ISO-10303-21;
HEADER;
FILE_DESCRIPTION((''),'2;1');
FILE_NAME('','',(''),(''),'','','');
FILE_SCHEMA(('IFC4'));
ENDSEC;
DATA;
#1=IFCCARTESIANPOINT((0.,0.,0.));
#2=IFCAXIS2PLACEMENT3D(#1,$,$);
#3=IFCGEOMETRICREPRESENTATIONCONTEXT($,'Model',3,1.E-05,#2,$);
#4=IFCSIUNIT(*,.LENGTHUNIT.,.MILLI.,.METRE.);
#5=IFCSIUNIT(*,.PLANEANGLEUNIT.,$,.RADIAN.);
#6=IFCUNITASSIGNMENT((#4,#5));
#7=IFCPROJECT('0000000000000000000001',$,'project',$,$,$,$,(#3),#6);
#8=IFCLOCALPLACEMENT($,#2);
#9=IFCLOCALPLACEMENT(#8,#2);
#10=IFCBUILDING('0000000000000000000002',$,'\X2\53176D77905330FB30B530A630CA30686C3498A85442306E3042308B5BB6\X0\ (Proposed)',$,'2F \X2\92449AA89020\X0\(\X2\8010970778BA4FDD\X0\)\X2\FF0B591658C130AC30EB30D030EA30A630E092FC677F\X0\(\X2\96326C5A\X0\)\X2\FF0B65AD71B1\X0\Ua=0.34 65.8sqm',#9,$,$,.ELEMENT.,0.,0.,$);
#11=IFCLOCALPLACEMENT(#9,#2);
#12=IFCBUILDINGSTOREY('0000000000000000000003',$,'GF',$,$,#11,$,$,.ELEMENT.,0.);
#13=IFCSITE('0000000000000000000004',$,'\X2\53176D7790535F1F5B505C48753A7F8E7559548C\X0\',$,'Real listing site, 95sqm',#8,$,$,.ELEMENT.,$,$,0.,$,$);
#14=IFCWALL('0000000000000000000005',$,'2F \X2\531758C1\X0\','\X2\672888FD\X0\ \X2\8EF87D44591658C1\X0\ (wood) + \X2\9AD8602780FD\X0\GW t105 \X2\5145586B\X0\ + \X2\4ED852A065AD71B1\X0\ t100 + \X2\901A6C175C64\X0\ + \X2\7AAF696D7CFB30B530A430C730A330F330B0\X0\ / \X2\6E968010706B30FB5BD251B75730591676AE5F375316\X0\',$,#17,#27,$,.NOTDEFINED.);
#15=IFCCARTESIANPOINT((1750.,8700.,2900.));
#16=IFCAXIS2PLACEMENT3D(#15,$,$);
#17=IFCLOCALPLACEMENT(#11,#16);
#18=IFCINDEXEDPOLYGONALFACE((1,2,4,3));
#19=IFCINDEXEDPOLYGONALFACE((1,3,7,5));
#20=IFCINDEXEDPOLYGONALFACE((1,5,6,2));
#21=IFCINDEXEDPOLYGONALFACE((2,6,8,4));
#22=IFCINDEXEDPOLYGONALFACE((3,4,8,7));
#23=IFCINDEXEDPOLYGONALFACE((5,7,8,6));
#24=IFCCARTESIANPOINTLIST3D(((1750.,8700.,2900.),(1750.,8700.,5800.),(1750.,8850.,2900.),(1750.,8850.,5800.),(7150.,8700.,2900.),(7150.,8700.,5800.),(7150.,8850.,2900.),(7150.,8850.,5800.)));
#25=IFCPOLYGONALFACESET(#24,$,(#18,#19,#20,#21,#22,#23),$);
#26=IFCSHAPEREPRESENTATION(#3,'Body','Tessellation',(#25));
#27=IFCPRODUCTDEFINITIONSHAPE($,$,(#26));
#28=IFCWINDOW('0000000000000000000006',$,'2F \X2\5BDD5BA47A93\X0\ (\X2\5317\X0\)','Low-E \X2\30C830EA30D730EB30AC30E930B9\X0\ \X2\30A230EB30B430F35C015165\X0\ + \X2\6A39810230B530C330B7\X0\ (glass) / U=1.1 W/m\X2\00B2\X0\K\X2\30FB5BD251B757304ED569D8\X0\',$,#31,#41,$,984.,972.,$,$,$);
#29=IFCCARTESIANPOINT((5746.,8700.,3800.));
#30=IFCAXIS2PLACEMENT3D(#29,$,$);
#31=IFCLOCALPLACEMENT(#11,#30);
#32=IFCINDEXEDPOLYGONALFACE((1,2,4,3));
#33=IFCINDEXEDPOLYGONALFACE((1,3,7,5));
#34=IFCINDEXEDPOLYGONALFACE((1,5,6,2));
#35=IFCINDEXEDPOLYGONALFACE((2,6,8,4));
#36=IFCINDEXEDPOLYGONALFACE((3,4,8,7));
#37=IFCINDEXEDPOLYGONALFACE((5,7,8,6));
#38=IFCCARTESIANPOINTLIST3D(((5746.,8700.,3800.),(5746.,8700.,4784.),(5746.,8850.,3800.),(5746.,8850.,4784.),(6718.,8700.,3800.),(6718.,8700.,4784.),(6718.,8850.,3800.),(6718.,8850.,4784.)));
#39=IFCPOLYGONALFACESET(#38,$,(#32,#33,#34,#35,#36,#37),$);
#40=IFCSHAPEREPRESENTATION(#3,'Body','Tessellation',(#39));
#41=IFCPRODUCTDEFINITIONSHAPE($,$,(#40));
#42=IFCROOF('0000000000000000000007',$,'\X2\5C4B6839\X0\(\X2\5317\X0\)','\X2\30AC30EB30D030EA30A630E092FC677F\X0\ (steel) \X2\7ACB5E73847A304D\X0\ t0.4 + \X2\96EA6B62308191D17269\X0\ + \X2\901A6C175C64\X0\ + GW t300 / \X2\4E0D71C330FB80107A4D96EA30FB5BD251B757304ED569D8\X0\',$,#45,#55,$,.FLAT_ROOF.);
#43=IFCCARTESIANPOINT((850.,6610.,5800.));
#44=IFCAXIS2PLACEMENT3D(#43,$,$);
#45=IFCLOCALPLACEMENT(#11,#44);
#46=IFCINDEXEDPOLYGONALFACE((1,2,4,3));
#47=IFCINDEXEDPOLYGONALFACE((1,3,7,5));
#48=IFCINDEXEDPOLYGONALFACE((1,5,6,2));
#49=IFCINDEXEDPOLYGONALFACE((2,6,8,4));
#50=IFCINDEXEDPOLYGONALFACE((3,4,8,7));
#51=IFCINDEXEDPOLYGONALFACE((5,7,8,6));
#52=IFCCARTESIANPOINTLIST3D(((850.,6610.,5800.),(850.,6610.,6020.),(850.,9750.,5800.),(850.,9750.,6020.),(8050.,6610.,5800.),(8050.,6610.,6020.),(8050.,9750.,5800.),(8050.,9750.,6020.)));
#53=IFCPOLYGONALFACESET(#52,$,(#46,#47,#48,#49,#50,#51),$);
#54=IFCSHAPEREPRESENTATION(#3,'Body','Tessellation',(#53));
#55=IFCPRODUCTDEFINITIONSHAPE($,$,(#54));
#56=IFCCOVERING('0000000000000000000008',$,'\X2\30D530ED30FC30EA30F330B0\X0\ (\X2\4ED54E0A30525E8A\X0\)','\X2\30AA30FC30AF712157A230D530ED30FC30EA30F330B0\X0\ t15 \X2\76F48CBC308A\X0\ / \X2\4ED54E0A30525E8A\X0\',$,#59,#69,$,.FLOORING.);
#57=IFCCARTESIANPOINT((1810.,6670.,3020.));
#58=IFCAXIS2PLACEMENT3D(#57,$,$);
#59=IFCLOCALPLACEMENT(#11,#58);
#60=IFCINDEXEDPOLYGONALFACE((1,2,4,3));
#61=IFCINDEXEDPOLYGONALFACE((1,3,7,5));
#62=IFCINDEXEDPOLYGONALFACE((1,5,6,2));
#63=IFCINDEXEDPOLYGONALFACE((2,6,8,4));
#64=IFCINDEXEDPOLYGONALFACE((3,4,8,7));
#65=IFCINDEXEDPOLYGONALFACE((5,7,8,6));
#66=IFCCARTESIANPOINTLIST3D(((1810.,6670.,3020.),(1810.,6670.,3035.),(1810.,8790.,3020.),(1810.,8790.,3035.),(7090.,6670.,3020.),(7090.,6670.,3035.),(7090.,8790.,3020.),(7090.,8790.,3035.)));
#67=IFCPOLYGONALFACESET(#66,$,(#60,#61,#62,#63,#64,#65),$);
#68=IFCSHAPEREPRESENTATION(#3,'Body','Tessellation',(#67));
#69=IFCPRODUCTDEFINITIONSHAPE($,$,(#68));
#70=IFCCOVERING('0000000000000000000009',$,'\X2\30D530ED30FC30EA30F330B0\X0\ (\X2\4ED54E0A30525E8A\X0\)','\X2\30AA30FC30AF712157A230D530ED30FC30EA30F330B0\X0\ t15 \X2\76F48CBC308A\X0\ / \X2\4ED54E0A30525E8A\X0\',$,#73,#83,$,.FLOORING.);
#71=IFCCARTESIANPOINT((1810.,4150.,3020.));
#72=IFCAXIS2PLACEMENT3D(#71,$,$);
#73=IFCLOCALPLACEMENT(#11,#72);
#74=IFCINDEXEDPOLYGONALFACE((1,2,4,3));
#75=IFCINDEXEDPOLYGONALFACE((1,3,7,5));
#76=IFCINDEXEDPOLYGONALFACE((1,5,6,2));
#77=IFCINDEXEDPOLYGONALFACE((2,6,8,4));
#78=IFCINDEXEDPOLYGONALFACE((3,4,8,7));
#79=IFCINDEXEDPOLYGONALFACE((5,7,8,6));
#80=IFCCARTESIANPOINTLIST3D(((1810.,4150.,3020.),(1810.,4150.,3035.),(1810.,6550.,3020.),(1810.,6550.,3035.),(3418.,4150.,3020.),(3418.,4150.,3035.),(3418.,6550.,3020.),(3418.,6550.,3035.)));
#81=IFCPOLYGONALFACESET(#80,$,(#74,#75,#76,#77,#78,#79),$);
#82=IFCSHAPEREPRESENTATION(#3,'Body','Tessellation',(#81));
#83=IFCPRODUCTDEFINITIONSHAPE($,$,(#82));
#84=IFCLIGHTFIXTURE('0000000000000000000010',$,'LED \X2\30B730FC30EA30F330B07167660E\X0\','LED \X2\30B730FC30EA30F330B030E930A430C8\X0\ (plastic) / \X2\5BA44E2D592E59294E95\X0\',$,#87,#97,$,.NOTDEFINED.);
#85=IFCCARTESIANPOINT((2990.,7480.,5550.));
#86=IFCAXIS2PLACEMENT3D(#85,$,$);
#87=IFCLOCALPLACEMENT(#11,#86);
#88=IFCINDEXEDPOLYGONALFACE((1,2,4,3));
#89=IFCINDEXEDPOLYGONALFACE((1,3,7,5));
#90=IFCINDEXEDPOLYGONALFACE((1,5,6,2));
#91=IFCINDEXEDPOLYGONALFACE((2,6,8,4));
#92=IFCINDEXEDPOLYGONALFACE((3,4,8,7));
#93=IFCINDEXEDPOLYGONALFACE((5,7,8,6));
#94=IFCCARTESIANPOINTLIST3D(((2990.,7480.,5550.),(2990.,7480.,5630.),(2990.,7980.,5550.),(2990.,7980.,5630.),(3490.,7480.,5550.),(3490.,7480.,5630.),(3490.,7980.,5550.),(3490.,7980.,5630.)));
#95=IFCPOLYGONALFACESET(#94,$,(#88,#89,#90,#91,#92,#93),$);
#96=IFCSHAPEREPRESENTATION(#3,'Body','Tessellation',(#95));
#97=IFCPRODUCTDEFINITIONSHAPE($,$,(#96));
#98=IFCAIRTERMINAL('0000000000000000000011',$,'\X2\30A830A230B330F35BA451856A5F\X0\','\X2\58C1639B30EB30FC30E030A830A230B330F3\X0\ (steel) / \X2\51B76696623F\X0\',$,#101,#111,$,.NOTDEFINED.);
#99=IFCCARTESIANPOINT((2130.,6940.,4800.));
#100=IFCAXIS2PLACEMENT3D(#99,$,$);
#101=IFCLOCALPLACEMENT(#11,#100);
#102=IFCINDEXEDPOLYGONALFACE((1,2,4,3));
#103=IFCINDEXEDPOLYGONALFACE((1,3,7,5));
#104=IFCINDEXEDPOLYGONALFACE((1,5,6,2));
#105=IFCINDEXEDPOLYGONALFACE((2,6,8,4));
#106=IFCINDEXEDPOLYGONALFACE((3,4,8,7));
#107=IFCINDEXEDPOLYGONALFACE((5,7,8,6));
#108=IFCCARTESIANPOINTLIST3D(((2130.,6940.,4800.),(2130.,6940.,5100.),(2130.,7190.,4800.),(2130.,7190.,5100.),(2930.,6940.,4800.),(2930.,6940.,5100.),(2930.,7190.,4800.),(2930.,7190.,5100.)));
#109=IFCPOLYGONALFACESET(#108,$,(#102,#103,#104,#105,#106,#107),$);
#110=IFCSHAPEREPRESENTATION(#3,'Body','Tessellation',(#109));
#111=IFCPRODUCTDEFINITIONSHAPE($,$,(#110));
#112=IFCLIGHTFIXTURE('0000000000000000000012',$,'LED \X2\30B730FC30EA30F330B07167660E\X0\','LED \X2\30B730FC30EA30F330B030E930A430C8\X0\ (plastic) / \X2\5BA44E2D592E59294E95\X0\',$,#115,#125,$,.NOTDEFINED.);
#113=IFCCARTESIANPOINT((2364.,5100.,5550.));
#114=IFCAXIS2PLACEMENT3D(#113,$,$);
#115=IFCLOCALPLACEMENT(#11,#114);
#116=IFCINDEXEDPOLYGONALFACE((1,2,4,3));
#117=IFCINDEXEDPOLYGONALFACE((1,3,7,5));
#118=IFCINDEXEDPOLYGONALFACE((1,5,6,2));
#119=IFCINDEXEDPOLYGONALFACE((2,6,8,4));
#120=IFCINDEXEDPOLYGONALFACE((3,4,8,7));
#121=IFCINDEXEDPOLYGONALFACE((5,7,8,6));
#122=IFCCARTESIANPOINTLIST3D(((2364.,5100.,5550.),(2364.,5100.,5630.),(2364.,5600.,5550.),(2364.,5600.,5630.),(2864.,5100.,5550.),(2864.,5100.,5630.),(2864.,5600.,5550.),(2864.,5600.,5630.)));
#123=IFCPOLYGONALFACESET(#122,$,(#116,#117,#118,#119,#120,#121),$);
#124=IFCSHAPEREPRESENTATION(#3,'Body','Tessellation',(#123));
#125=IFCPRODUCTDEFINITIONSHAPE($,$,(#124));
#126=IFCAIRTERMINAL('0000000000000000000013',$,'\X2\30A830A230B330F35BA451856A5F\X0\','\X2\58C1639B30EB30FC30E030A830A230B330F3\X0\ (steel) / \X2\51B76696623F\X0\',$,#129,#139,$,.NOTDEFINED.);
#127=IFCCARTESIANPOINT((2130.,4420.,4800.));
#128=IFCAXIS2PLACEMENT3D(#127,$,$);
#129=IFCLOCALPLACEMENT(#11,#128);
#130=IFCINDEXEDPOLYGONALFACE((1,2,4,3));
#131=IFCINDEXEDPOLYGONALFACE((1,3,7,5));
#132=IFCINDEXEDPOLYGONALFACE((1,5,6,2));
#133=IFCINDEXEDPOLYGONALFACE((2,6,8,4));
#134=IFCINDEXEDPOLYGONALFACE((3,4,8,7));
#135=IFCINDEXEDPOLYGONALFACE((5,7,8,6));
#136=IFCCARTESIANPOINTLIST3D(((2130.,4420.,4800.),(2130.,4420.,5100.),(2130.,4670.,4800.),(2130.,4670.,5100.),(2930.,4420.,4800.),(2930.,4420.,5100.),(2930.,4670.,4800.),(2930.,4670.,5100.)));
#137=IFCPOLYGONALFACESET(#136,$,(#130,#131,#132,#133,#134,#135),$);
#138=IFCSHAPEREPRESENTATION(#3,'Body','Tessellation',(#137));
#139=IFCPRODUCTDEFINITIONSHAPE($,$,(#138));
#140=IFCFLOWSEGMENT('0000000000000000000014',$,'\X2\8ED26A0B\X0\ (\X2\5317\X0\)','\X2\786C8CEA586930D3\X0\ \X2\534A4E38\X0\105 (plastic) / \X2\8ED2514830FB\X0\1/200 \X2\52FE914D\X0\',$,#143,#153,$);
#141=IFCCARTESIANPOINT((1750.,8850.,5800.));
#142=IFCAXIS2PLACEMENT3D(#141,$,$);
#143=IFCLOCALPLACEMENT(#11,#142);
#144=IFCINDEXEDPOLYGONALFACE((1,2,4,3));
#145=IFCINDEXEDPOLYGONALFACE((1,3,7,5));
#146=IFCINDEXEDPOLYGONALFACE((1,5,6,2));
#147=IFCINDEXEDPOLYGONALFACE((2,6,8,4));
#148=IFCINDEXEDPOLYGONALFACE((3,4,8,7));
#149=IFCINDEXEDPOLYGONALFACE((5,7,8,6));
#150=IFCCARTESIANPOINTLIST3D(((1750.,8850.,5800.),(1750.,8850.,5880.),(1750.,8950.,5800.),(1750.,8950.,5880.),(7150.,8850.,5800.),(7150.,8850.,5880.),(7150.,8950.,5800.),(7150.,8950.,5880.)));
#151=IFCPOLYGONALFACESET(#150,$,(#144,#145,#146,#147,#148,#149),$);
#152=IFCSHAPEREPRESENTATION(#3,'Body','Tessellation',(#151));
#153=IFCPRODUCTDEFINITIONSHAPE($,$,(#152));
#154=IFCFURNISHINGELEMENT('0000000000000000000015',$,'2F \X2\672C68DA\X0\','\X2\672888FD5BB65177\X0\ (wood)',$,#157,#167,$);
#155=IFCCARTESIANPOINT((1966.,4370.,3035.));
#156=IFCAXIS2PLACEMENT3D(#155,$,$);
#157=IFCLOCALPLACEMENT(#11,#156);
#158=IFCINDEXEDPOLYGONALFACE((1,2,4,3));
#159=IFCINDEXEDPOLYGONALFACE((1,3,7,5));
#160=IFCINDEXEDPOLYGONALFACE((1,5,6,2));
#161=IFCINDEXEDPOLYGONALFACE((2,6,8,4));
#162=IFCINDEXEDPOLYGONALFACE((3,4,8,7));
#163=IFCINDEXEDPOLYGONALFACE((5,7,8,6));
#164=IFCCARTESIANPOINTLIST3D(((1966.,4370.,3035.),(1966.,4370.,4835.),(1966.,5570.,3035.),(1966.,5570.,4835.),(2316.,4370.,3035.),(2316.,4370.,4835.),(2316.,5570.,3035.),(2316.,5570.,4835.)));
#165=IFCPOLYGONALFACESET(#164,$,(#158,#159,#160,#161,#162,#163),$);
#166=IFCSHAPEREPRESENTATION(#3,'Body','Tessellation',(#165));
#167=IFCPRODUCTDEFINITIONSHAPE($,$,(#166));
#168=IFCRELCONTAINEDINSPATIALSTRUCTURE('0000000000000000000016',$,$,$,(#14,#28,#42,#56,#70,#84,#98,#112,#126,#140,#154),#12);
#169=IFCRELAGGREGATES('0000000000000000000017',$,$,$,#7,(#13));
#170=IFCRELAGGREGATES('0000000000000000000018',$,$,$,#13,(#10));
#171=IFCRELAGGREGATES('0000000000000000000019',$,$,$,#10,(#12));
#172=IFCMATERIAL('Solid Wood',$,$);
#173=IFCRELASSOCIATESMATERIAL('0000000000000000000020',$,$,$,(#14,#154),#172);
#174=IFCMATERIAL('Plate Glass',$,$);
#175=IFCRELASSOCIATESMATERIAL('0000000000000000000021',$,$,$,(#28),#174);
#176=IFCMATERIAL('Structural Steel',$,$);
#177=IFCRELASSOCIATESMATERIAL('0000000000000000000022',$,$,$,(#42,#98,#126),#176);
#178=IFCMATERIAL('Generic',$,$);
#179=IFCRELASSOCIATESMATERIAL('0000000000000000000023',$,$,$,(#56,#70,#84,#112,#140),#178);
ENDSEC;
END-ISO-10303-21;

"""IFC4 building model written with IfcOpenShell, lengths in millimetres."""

from ifc_helpers import new_model, si_unit, frame, frame_2d, origin, place, context, project, spatial, rectangle, extrude, material, element, fill, save


model = new_model("IFC4")

# Units and contexts
model_context = context("Model", 3, precision=1e-05, world=origin())
ifc_project = project(units=[si_unit("LENGTHUNIT", "METRE", prefix="MILLI"), si_unit("PLANEANGLEUNIT", "RADIAN")], contexts=[model_context])

# Site, building, storey
site_placement = place(None, origin())
site = spatial("IfcSite", under=ifc_project, at=site_placement, Name="北海道弟子屈町美留和", ObjectType="Real listing site, 95sqm", CompositionType="ELEMENT", RefElevation=0.0)
building_placement = place(site_placement, origin())
building = spatial("IfcBuilding", under=site, at=building_placement, Name="北海道・サウナと水風呂のある家 (Proposed)", ObjectType="2F 鉄骨造(耐震確保)＋外壁ガルバリウム鋼板(防汚)＋断熱Ua=0.34 65.8sqm", CompositionType="ELEMENT", ElevationOfRefHeight=0.0, ElevationOfTerrain=0.0)
storey_placement = place(building_placement, origin())
storey = spatial("IfcBuildingStorey", under=building, at=storey_placement, Name="GF", CompositionType="ELEMENT", Elevation=0.0)

# Shared definitions
ifc_material_1 = material(Name="Solid Wood")

# Wall, opening, window
wall_placement = place(storey_placement, frame((1750.0, 8700.0, 2900.0)))
wall = element("IfcWall", 1, at=wall_placement, inside=storey, material=ifc_material_1, Name="2F 北壁", Description="木製 軸組外壁 (wood) + 高性能GW t105 充填 + 付加断熱 t100 + 通気層 + 窯業系サイディング / 準耐火・寒冷地外皮強化", PredefinedType="NOTDEFINED", context=model_context, shape_type="SweptSolid", body=[
    extrude(rectangle(XDim=5400.0, YDim=150.0, at=frame_2d((2700.0, 75.0))), frame((1750.0, 8700.0, 2900.0)), (0.0, 0.0, 1.0), 2900.0),
])
opening_placement = place(storey_placement, frame((5746.0, 8700.0, 3800.0)))
opening = element("IfcOpeningElement", 2, at=opening_placement, cuts=wall, PredefinedType="NOTDEFINED", context=model_context, shape_type="SweptSolid", body=[
    extrude(rectangle(XDim=972.0, YDim=150.0, at=frame_2d((486.0, 75.0))), frame((5746.0, 8700.0, 3800.0)), (0.0, 0.0, 1.0), 984.0),
])
ifc_material_2 = material(Name="Plate Glass")
window_placement = place(storey_placement, frame((5746.0, 8700.0, 3800.0)))
window = element("IfcWindow", 3, at=window_placement, inside=storey, material=ifc_material_2, Name="2F 寝室窓 (北)", Description="Low-E トリプルガラス アルゴン封入 + 樹脂サッシ (glass) / U=1.1 W/m²K・寒冷地仕様", OverallHeight=984.0, OverallWidth=972.0, context=model_context, shape_type="SweptSolid", body=[
    extrude(rectangle(XDim=972.0, YDim=150.0, at=frame_2d((486.0, 75.0))), frame((5746.0, 8700.0, 3800.0)), (0.0, 0.0, 1.0), 984.0),
])
fill(opening, window)

# Roof
ifc_material_3 = material(Name="Structural Steel")
for number, where, name in (
    (4, (850.0, 6610.0, 5800.0), "屋根(北)"),
):
    element("IfcRoof", number, at=place(storey_placement, frame(where)), inside=storey, material=ifc_material_3, Name=name, Description="ガルバリウム鋼板 (steel) 立平葺き t0.4 + 雪止め金物 + 通気層 + GW t300 / 不燃・耐積雪・寒冷地仕様", PredefinedType="FLAT_ROOF", context=model_context, shape_type="SweptSolid", body=[
        extrude(rectangle(XDim=7200.0, YDim=3140.0, at=frame_2d((3600.0, 1570.0))), frame((850.0, 6610.0, 5800.0)), (0.0, 0.0, 1.0), 220.0),
    ])

# Coverings
ifc_material_4 = material(Name="Generic")
covering_1_placement = place(storey_placement, frame((1810.0, 6670.0, 3020.0)))
element("IfcCovering", 5, at=covering_1_placement, inside=storey, material=ifc_material_4, Name="フローリング (仕上げ床)", Description="オーク無垢フローリング t15 直貼り / 仕上げ床", PredefinedType="FLOORING", context=model_context, shape_type="SweptSolid", body=[
    extrude(rectangle(XDim=5280.0, YDim=2120.0, at=frame_2d((2640.0, 1060.0))), frame((1810.0, 6670.0, 3020.0)), (0.0, 0.0, 1.0), 15.0),
])
covering_2_placement = place(storey_placement, frame((1810.0, 4150.0, 3020.0)))
element("IfcCovering", 6, at=covering_2_placement, inside=storey, material=ifc_material_4, Name="フローリング (仕上げ床)", Description="オーク無垢フローリング t15 直貼り / 仕上げ床", PredefinedType="FLOORING", context=model_context, shape_type="SweptSolid", body=[
    extrude(rectangle(XDim=1608.0, YDim=2400.0, at=frame_2d((804.0, 1200.0))), frame((1810.0, 4150.0, 3020.0)), (0.0, 0.0, 1.0), 15.0),
])

# Light fixture
light_fixture_1_placement = place(storey_placement, frame((2990.0, 7480.0, 5550.0)))
element("IfcLightFixture", 7, at=light_fixture_1_placement, inside=storey, material=ifc_material_4, Name="LED シーリング照明", Description="LED シーリングライト (plastic) / 室中央天井", PredefinedType="NOTDEFINED", context=model_context, shape_type="SweptSolid", body=[
    extrude(rectangle(XDim=500.0, YDim=500.0, at=frame_2d((250.0, 250.0))), frame((2990.0, 7480.0, 5550.0)), (0.0, 0.0, 1.0), 80.0),
])

# Air terminal
air_terminal_1_placement = place(storey_placement, frame((2130.0, 6940.0, 4800.0)))
element("IfcAirTerminal", 8, at=air_terminal_1_placement, inside=storey, material=ifc_material_3, Name="エアコン室内機", Description="壁掛ルームエアコン (steel) / 冷暖房", PredefinedType="NOTDEFINED", context=model_context, shape_type="SweptSolid", body=[
    extrude(rectangle(XDim=800.0, YDim=250.0, at=frame_2d((400.0, 125.0))), frame((2130.0, 6940.0, 4800.0)), (0.0, 0.0, 1.0), 300.0),
])

# Light fixture
light_fixture_2_placement = place(storey_placement, frame((2364.0, 5100.0, 5550.0)))
element("IfcLightFixture", 9, at=light_fixture_2_placement, inside=storey, material=ifc_material_4, Name="LED シーリング照明", Description="LED シーリングライト (plastic) / 室中央天井", PredefinedType="NOTDEFINED", context=model_context, shape_type="SweptSolid", body=[
    extrude(rectangle(XDim=500.0, YDim=500.0, at=frame_2d((250.0, 250.0))), frame((2364.0, 5100.0, 5550.0)), (0.0, 0.0, 1.0), 80.0),
])

# Air terminal
air_terminal_2_placement = place(storey_placement, frame((2130.0, 4420.0, 4800.0)))
element("IfcAirTerminal", 10, at=air_terminal_2_placement, inside=storey, material=ifc_material_3, Name="エアコン室内機", Description="壁掛ルームエアコン (steel) / 冷暖房", PredefinedType="NOTDEFINED", context=model_context, shape_type="SweptSolid", body=[
    extrude(rectangle(XDim=800.0, YDim=250.0, at=frame_2d((400.0, 125.0))), frame((2130.0, 4420.0, 4800.0)), (0.0, 0.0, 1.0), 300.0),
])

# Flow segment
flow_segment_placement = place(storey_placement, frame((1750.0, 8850.0, 5800.0)))
element("IfcFlowSegment", 11, at=flow_segment_placement, inside=storey, material=ifc_material_4, Name="軒樋 (北)", Description="硬質塩ビ 半丸105 (plastic) / 軒先・1/200 勾配", context=model_context, shape_type="SweptSolid", body=[
    extrude(rectangle(XDim=5400.0, YDim=100.0, at=frame_2d((2700.0, 50.0))), frame((1750.0, 8850.0, 5800.0)), (0.0, 0.0, 1.0), 80.0),
])

# Furnishing element
furnishing_placement = place(storey_placement, frame((1966.0, 4370.0, 3035.0)))
element("IfcFurnishingElement", 12, at=furnishing_placement, inside=storey, material=ifc_material_1, Name="2F 本棚", Description="木製家具 (wood)", context=model_context, shape_type="SweptSolid", body=[
    extrude(rectangle(XDim=350.0, YDim=1200.0, at=frame_2d((175.0, 600.0))), frame((1966.0, 4370.0, 3035.0)), (0.0, 0.0, 1.0), 1800.0),
])

save(model, "model.ifc")
